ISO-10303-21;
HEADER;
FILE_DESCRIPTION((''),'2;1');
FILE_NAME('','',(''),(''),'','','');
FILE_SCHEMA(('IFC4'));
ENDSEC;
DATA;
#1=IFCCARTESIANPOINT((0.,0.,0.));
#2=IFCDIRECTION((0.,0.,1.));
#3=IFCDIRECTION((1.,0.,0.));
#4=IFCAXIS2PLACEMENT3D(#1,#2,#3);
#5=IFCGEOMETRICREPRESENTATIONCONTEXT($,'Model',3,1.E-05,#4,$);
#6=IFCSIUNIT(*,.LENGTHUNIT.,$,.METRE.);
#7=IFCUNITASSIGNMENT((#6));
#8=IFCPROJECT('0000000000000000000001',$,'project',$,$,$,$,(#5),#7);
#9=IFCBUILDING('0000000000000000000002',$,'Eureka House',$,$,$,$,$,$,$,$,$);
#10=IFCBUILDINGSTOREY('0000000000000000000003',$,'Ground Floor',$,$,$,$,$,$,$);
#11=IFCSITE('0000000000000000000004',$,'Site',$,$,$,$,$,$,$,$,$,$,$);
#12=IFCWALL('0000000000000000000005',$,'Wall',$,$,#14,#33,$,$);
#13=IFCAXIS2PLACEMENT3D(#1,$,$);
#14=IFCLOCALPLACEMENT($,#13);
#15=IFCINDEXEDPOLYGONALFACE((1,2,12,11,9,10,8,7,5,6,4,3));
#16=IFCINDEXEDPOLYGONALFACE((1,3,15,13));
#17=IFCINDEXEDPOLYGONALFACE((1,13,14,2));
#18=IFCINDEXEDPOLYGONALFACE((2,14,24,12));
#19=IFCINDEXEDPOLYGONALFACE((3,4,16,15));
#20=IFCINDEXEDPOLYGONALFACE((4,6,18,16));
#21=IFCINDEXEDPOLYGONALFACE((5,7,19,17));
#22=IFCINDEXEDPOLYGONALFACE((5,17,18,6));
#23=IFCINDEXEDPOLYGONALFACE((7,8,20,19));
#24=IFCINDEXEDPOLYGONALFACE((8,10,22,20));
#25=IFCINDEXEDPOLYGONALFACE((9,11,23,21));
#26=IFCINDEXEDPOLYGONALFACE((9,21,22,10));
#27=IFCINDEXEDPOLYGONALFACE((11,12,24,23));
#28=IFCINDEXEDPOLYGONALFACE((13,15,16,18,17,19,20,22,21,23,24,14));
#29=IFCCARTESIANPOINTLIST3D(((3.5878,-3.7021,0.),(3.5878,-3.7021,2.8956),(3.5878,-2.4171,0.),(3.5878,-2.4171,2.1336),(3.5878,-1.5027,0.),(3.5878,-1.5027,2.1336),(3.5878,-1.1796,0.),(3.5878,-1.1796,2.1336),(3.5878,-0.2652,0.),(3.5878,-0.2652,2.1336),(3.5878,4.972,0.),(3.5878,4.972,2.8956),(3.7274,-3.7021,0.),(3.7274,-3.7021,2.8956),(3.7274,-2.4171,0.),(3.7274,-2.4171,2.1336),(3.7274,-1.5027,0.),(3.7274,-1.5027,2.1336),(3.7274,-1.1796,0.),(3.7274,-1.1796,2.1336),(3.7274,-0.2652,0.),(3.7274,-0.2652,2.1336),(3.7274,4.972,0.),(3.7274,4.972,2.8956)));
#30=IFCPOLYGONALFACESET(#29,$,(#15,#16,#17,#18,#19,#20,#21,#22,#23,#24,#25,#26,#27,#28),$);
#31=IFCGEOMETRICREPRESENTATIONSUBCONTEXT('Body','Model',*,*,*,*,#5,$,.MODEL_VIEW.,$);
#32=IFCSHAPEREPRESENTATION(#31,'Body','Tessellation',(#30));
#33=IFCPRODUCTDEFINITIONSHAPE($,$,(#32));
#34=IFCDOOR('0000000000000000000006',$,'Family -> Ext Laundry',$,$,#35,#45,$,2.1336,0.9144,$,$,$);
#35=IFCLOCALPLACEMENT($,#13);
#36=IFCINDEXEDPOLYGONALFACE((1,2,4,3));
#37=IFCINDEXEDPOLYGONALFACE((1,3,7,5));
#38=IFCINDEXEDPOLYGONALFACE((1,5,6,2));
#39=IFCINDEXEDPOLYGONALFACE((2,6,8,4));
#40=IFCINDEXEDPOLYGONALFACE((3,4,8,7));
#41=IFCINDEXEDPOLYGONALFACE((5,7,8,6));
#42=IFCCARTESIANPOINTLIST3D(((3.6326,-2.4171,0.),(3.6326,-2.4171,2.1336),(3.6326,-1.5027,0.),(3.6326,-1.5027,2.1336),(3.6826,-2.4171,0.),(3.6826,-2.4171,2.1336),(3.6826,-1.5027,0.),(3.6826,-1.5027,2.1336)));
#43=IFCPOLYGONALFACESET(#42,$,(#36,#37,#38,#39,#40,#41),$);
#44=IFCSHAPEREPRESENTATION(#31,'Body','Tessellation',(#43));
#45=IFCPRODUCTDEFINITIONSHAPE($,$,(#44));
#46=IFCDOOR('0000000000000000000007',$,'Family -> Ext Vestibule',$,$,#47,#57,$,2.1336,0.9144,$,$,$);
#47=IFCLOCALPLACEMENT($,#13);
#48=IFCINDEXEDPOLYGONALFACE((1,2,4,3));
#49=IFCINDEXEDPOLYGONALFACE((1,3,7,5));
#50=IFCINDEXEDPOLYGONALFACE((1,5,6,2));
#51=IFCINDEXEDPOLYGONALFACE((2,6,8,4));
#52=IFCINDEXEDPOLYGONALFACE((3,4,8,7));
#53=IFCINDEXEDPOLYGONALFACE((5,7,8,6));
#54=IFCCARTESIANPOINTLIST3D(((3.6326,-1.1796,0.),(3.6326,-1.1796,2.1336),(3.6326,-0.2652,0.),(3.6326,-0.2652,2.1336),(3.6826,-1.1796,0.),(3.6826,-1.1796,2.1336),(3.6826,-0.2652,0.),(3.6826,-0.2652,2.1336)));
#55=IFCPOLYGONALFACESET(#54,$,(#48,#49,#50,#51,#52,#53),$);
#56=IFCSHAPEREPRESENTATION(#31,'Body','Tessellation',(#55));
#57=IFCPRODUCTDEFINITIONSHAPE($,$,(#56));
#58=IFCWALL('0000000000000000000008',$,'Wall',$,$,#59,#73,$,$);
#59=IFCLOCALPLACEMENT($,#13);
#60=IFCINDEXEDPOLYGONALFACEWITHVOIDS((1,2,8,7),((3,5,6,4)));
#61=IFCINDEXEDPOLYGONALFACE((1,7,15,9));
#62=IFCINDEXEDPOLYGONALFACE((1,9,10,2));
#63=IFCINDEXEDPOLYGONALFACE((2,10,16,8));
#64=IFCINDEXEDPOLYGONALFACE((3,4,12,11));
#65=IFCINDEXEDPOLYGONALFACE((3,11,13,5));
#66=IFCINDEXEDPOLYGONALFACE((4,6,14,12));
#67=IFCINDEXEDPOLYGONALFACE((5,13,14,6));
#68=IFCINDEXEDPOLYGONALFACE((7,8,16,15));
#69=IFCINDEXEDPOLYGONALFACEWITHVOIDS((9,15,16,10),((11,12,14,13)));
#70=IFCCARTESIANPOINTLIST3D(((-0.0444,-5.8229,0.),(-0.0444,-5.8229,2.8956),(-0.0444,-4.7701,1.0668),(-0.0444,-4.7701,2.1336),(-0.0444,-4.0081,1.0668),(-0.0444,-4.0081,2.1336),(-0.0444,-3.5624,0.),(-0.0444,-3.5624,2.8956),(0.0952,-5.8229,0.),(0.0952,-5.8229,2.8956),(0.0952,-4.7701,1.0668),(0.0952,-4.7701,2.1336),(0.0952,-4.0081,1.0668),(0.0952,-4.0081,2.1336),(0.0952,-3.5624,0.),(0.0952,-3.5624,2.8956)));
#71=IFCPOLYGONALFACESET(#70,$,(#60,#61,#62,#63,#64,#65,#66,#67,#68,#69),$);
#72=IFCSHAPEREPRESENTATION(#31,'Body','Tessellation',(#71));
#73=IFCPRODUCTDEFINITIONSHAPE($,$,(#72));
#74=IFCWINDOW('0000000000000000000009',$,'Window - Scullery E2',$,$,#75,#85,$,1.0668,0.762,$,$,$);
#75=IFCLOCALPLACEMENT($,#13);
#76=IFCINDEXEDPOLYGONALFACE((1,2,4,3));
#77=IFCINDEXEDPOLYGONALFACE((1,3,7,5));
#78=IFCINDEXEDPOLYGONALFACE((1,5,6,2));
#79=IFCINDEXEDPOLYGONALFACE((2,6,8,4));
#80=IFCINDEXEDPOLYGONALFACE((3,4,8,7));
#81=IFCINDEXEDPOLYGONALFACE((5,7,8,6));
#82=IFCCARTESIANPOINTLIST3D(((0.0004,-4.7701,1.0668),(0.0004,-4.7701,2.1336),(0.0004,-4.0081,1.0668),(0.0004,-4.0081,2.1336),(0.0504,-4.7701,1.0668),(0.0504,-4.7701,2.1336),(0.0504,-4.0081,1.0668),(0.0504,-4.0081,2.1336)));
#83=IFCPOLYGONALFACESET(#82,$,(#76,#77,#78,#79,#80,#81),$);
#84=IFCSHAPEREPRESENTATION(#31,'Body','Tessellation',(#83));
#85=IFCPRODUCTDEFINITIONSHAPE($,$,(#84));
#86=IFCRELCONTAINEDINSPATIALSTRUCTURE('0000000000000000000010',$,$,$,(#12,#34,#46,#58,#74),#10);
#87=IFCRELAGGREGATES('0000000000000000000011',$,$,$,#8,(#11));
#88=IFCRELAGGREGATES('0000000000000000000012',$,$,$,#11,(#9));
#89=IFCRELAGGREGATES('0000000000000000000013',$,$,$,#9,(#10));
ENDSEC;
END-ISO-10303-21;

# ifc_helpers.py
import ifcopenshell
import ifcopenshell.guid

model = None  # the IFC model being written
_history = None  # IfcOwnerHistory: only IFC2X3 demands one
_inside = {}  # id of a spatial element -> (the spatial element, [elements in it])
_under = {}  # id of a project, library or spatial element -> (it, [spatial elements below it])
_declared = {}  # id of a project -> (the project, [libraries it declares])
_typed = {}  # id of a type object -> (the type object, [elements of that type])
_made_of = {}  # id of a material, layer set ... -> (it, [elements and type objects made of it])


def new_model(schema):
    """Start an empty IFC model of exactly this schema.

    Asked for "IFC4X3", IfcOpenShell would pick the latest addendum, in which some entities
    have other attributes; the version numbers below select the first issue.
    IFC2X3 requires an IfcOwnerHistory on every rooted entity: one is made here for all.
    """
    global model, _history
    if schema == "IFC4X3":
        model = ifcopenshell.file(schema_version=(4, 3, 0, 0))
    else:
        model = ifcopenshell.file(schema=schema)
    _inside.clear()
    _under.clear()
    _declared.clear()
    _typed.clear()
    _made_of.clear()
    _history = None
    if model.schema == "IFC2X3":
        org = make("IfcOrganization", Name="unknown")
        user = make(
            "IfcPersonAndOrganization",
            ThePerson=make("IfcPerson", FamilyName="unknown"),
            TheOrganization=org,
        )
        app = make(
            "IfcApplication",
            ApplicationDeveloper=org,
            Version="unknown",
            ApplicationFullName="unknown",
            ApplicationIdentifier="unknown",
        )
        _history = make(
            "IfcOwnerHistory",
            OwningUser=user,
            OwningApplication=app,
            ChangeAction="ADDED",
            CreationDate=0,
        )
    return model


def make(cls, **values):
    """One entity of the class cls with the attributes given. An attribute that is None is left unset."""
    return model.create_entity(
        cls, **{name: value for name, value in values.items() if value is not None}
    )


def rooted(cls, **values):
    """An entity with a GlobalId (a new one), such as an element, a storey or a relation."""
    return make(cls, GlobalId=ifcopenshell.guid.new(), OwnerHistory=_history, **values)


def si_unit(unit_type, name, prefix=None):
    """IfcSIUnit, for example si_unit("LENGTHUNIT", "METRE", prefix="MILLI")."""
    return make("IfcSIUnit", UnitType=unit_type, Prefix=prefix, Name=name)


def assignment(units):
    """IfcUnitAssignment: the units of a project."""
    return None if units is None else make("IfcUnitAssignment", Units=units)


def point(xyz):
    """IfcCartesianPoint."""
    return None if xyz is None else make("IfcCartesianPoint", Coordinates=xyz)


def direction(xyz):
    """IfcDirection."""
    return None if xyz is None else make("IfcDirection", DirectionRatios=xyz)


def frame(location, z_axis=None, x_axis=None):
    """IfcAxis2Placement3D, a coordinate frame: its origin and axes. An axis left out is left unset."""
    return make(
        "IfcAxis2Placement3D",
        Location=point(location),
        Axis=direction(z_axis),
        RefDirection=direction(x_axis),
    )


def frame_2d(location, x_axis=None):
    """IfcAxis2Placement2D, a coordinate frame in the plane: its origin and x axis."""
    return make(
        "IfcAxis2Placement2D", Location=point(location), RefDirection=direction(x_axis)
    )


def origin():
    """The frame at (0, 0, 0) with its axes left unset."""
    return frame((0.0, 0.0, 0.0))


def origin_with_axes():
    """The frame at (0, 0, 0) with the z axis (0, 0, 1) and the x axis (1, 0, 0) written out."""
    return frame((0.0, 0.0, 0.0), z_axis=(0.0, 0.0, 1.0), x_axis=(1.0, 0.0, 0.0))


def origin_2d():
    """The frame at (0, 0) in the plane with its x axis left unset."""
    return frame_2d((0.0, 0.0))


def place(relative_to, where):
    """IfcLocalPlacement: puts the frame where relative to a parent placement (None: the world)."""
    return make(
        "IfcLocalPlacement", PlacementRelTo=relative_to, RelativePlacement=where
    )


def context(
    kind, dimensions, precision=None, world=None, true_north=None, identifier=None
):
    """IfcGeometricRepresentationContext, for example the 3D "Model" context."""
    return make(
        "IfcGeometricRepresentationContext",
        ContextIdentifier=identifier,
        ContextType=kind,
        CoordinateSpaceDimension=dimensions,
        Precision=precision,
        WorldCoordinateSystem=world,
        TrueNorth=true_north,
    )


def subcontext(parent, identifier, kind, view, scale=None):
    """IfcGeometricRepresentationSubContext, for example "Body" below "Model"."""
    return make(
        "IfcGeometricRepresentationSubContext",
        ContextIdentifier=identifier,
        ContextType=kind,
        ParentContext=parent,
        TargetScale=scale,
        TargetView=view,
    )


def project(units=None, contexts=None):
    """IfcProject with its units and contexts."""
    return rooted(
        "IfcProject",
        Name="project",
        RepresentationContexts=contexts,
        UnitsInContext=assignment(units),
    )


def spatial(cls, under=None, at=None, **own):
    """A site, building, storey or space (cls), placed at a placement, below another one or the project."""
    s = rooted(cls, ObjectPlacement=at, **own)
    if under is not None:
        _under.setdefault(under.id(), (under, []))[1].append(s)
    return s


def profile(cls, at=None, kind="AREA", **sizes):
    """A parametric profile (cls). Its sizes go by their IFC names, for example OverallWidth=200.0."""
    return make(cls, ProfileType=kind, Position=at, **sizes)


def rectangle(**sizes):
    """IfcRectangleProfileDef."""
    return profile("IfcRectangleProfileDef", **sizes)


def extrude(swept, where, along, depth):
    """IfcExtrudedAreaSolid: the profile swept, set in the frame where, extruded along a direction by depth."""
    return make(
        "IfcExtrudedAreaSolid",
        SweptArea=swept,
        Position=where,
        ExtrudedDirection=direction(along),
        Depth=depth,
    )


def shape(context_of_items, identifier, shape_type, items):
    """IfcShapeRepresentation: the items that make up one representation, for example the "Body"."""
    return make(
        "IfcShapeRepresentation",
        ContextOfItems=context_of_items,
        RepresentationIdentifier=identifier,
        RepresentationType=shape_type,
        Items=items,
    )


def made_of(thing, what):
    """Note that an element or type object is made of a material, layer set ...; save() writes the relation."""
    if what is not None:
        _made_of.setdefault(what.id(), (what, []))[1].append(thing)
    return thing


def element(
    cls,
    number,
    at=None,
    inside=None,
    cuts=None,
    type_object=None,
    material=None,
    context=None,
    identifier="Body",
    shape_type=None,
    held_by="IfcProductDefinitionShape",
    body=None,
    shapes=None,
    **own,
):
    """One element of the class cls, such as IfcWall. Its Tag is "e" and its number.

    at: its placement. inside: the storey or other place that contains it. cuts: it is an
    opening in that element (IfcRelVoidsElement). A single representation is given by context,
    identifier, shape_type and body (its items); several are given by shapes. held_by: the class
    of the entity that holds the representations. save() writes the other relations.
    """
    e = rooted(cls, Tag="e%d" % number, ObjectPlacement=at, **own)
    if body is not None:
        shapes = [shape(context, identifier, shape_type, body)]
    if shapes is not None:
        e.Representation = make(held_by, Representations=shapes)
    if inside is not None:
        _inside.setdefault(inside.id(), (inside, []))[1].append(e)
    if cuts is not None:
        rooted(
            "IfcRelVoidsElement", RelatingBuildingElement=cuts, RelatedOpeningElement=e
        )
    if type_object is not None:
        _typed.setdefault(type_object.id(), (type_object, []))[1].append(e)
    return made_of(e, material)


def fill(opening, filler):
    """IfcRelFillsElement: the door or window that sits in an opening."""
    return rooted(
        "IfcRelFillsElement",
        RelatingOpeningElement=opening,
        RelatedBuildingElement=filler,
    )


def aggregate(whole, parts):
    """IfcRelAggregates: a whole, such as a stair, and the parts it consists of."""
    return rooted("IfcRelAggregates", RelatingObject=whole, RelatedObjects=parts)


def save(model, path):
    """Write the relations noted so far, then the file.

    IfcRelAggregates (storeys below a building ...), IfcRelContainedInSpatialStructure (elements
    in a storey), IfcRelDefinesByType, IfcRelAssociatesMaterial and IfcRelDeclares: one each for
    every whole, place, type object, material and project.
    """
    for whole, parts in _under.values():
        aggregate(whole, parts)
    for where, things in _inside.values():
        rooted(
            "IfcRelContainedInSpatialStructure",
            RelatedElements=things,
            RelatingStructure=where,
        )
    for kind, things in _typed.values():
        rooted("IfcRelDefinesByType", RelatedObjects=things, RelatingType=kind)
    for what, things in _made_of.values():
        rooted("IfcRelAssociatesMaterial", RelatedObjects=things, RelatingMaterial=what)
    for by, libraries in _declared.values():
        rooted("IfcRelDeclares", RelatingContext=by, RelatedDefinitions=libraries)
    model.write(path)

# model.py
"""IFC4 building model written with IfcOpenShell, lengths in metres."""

from ifc_helpers import new_model, si_unit, frame, origin, origin_with_axes, origin_2d, place, context, subcontext, project, spatial, rectangle, extrude, element, fill, save


model = new_model("IFC4")

# Units and contexts
model_context = context("Model", 3, precision=1e-05, world=origin_with_axes())
body_context = subcontext(model_context, "Body", "Model", "MODEL_VIEW")
ifc_project = project(units=[si_unit("LENGTHUNIT", "METRE")], contexts=[model_context])

# Site, building, storey
site = spatial("IfcSite", under=ifc_project, Name="Site")
building = spatial("IfcBuilding", under=site, Name="Eureka House")
storey = spatial("IfcBuildingStorey", under=building, Name="Ground Floor")

# Wall, openings, doors
wall_1_placement = place(None, frame((3.6576, 0.635, 0.0), z_axis=(0.0, 0.0, 1.0), x_axis=(1.0, 0.0, 0.0)))
wall_1 = element("IfcWall", 1, at=wall_1_placement, inside=storey, Name="Wall", context=body_context, shape_type="SweptSolid", body=[
    extrude(rectangle(XDim=0.1397, YDim=8.6741, at=origin_2d()), origin(), (0.0, 0.0, 1.0), 2.8956),
])
opening_1_placement = place(wall_1_placement, frame((0.0, -2.5949, 0.0), z_axis=(0.0, 0.0, 1.0), x_axis=(1.0, 0.0, 0.0)))
opening_1 = element("IfcOpeningElement", 2, at=opening_1_placement, cuts=wall_1, context=body_context, shape_type="SweptSolid", body=[
    extrude(rectangle(XDim=0.2397, YDim=0.9144, at=origin_2d()), origin(), (0.0, 0.0, 1.0), 2.1336),
])
opening_2_placement = place(wall_1_placement, frame((0.0, -1.3574, 0.0), z_axis=(0.0, 0.0, 1.0), x_axis=(1.0, 0.0, 0.0)))
opening_2 = element("IfcOpeningElement", 3, at=opening_2_placement, cuts=wall_1, context=body_context, shape_type="SweptSolid", body=[
    extrude(rectangle(XDim=0.2397, YDim=0.9144, at=origin_2d()), origin(), (0.0, 0.0, 1.0), 2.1336),
])
door_1_placement = place(opening_1_placement, origin_with_axes())
door_1 = element("IfcDoor", 4, at=door_1_placement, inside=storey, Name="Family -> Ext Laundry", OverallHeight=2.1336, OverallWidth=0.9144, context=body_context, shape_type="SweptSolid", body=[
    extrude(rectangle(XDim=0.05, YDim=0.9144, at=origin_2d()), origin(), (0.0, 0.0, 1.0), 2.1336),
])
fill(opening_1, door_1)
door_2_placement = place(opening_2_placement, frame((0.0, 0.0, 0.0), z_axis=(0.0, 0.0, 1.0), x_axis=(1.0, 0.0, 0.0)))
door_2 = element("IfcDoor", 5, at=door_2_placement, inside=storey, Name="Family -> Ext Vestibule", OverallHeight=2.1336, OverallWidth=0.9144, context=body_context, shape_type="SweptSolid", body=[
    extrude(rectangle(XDim=0.05, YDim=0.9144, at=origin_2d()), origin(), (0.0, 0.0, 1.0), 2.1336),
])
fill(opening_2, door_2)

# Wall, opening, window
wall_2_placement = place(None, frame((0.0254, -4.6927, 0.0), z_axis=(0.0, 0.0, 1.0), x_axis=(1.0, 0.0, 0.0)))
wall_2 = element("IfcWall", 6, at=wall_2_placement, inside=storey, Name="Wall", context=body_context, shape_type="SweptSolid", body=[
    extrude(rectangle(XDim=0.1397, YDim=2.2606, at=origin_2d()), origin(), (0.0, 0.0, 1.0), 2.8956),
])
opening_3_placement = place(wall_2_placement, frame((0.0, 0.3035, 1.0668), z_axis=(0.0, 0.0, 1.0), x_axis=(1.0, 0.0, 0.0)))
opening_3 = element("IfcOpeningElement", 7, at=opening_3_placement, cuts=wall_2, context=body_context, shape_type="SweptSolid", body=[
    extrude(rectangle(XDim=0.2397, YDim=0.762, at=origin_2d()), origin(), (0.0, 0.0, 1.0), 1.0668),
])
window_1_placement = place(opening_3_placement, origin_with_axes())
window_1 = element("IfcWindow", 8, at=window_1_placement, inside=storey, Name="Window - Scullery E2", OverallHeight=1.0668, OverallWidth=0.762, context=body_context, shape_type="SweptSolid", body=[
    extrude(rectangle(XDim=0.05, YDim=0.762, at=origin_2d()), origin(), (0.0, 0.0, 1.0), 1.0668),
])
fill(opening_3, window_1)

save(model, "model.ifc")
